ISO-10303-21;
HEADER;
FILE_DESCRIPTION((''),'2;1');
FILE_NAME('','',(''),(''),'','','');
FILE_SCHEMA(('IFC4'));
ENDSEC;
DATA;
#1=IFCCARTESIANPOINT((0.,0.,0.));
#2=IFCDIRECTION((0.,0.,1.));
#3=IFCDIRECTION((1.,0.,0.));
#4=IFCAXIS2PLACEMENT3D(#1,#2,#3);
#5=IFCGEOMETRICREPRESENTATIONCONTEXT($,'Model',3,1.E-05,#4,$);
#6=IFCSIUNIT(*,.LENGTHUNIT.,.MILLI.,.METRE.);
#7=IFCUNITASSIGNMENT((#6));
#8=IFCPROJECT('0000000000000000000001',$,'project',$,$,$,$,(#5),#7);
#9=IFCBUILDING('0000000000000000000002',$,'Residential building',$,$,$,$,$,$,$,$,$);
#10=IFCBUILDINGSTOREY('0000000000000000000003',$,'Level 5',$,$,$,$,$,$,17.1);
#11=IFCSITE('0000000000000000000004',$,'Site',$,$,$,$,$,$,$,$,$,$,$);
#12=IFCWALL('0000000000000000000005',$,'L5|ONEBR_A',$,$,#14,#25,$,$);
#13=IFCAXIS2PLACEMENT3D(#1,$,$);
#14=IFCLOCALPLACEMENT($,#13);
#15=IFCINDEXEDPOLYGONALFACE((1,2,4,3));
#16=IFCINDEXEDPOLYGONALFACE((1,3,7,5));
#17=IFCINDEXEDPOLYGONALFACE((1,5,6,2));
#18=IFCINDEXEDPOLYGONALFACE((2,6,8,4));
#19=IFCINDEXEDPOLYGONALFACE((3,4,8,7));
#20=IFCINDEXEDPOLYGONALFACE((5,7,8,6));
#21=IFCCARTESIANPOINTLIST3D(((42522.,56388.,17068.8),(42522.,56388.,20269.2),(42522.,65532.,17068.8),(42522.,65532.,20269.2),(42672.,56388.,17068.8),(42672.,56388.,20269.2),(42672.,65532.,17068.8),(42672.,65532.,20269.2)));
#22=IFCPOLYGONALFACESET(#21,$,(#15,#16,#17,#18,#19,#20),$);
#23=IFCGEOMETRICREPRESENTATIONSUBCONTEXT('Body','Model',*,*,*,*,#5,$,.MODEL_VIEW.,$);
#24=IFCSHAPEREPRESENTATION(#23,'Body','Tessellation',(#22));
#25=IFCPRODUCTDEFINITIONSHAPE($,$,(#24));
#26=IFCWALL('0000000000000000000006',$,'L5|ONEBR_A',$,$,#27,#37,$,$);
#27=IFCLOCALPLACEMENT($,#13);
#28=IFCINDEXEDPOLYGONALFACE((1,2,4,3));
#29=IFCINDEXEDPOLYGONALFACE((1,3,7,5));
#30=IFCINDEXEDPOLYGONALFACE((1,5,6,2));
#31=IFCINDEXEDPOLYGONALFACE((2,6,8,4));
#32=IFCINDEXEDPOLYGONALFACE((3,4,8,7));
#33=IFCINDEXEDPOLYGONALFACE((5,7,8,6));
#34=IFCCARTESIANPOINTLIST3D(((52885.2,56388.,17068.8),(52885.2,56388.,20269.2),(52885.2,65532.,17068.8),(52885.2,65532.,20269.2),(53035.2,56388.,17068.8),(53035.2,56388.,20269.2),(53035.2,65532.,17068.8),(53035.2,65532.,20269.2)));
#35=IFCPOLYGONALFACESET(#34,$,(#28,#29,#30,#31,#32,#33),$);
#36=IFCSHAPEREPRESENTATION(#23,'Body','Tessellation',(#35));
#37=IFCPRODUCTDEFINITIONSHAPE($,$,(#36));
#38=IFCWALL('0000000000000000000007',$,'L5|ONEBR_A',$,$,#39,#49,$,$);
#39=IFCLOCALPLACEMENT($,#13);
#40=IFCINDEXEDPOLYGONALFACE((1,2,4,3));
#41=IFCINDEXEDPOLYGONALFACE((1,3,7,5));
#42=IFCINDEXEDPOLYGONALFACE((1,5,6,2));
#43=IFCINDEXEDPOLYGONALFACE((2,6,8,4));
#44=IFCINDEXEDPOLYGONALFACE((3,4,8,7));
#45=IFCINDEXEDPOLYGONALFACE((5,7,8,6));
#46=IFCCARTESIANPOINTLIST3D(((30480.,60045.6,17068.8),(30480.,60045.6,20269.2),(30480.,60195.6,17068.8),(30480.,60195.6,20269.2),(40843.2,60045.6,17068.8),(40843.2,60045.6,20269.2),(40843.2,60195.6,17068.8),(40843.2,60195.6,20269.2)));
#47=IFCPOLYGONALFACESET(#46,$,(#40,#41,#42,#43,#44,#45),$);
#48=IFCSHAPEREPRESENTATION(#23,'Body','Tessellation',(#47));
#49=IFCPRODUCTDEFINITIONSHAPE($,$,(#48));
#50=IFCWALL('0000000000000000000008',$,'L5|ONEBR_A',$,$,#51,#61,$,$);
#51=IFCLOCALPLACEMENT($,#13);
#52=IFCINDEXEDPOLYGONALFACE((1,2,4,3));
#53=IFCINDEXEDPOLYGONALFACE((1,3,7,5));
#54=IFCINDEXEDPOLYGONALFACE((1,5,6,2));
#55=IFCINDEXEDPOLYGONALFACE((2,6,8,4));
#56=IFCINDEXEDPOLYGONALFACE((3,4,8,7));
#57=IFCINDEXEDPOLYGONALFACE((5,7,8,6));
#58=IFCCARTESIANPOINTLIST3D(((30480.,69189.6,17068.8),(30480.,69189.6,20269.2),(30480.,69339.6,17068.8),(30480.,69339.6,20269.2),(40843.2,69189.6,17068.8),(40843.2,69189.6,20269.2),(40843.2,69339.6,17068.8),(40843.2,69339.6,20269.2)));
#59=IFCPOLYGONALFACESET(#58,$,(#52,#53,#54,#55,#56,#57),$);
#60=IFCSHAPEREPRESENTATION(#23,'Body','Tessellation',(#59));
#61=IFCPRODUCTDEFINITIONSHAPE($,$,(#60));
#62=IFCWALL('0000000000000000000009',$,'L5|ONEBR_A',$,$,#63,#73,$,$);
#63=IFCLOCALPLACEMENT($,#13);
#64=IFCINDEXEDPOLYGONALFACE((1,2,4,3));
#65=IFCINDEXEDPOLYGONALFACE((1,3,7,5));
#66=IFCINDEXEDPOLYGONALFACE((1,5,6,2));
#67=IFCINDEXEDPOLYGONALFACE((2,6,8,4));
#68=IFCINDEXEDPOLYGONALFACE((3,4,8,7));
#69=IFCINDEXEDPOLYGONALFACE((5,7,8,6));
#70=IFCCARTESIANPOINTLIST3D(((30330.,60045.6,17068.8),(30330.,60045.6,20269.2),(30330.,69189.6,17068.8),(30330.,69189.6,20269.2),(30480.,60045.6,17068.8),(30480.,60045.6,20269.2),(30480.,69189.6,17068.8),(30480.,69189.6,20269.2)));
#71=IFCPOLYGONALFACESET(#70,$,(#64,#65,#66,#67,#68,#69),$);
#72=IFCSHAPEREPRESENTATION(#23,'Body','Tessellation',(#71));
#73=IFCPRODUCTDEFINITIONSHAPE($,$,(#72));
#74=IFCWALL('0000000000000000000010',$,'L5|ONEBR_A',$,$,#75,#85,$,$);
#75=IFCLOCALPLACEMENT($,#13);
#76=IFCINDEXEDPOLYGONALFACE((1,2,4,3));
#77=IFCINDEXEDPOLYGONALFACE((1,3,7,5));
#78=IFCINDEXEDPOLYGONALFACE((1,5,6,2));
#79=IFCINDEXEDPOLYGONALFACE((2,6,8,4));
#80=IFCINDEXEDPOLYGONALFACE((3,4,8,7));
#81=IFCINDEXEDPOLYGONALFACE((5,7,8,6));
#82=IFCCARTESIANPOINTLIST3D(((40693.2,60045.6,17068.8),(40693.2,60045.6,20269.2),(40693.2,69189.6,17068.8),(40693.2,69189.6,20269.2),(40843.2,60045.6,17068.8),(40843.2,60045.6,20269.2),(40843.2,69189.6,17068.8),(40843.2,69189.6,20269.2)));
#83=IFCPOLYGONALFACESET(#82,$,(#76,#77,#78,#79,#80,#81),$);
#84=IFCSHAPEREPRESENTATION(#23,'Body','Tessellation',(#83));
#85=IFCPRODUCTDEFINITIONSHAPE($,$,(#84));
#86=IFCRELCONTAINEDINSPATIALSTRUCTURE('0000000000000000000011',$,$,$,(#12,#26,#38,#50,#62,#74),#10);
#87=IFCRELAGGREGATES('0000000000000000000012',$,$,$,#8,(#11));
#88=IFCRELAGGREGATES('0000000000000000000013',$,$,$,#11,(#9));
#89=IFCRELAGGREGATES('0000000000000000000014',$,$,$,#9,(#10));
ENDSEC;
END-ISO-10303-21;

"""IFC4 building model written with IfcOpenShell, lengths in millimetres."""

from ifc_helpers import new_model, si_unit, frame, origin_with_axes, place, context, subcontext, project, spatial, indexed_curve, outline, extrude, element, save


model = new_model("IFC4")

# Units and contexts
model_context = context("Model", 3, precision=1e-05, world=origin_with_axes())
body_context = subcontext(model_context, "Body", "Model", "MODEL_VIEW")
ifc_project = project(units=[si_unit("LENGTHUNIT", "METRE", prefix="MILLI")], contexts=[model_context])

# Site, building, storey
site = spatial("IfcSite", under=ifc_project, Name="Site")
building = spatial("IfcBuilding", under=site, Name="Residential building")
storey = spatial("IfcBuildingStorey", under=building, Name="Level 5", Elevation=17.1)

# Walls
for number, where, z_axis, x_axis, name in (
    (1, (42672.0, 56388.0, 17068.8), (0.0, 0.0, 1.0), (0.0, 1.0, 0.0), "L5|ONEBR_A"),
    (2, (53035.2, 56388.0, 17068.8), (0.0, 0.0, 1.0), (0.0, 1.0, 0.0), "L5|ONEBR_A"),
):
    element("IfcWall", number, at=place(None, frame(where, z_axis=z_axis, x_axis=x_axis)), inside=storey, Name=name, context=body_context, shape_type="SweptSolid", body=[
        extrude(outline(indexed_curve([(0.0, 0.0), (0.0, 150.0), (9144.0, 150.0), (9144.0, 0.0), (0.0, 0.0)], self_intersect=False)), origin_with_axes(), (0.0, 0.0, 1.0), 3200.4),
    ])
for number, where, z_axis, x_axis, name in (
    (3, (30480.0, 60045.6, 17068.8), (0.0, 0.0, 1.0), (1.0, 0.0, 0.0), "L5|ONEBR_A"),
    (4, (30480.0, 69189.6, 17068.8), (0.0, 0.0, 1.0), (1.0, 0.0, 0.0), "L5|ONEBR_A"),
):
    element("IfcWall", number, at=place(None, frame(where, z_axis=z_axis, x_axis=x_axis)), inside=storey, Name=name, context=body_context, shape_type="SweptSolid", body=[
        extrude(outline(indexed_curve([(0.0, 0.0), (0.0, 150.0), (10363.2, 150.0), (10363.2, 0.0), (0.0, 0.0)], self_intersect=False)), origin_with_axes(), (0.0, 0.0, 1.0), 3200.4),
    ])
for number, where, z_axis, x_axis, name in (
    (5, (30480.0, 60045.6, 17068.8), (0.0, 0.0, 1.0), (0.0, 1.0, 0.0), "L5|ONEBR_A"),
    (6, (40843.2, 60045.6, 17068.8), (0.0, 0.0, 1.0), (0.0, 1.0, 0.0), "L5|ONEBR_A"),
):
    element("IfcWall", number, at=place(None, frame(where, z_axis=z_axis, x_axis=x_axis)), inside=storey, Name=name, context=body_context, shape_type="SweptSolid", body=[
        extrude(outline(indexed_curve([(0.0, 0.0), (0.0, 150.0), (9144.0, 150.0), (9144.0, 0.0), (0.0, 0.0)], self_intersect=False)), origin_with_axes(), (0.0, 0.0, 1.0), 3200.4),
    ])

save(model, "model.ifc")
